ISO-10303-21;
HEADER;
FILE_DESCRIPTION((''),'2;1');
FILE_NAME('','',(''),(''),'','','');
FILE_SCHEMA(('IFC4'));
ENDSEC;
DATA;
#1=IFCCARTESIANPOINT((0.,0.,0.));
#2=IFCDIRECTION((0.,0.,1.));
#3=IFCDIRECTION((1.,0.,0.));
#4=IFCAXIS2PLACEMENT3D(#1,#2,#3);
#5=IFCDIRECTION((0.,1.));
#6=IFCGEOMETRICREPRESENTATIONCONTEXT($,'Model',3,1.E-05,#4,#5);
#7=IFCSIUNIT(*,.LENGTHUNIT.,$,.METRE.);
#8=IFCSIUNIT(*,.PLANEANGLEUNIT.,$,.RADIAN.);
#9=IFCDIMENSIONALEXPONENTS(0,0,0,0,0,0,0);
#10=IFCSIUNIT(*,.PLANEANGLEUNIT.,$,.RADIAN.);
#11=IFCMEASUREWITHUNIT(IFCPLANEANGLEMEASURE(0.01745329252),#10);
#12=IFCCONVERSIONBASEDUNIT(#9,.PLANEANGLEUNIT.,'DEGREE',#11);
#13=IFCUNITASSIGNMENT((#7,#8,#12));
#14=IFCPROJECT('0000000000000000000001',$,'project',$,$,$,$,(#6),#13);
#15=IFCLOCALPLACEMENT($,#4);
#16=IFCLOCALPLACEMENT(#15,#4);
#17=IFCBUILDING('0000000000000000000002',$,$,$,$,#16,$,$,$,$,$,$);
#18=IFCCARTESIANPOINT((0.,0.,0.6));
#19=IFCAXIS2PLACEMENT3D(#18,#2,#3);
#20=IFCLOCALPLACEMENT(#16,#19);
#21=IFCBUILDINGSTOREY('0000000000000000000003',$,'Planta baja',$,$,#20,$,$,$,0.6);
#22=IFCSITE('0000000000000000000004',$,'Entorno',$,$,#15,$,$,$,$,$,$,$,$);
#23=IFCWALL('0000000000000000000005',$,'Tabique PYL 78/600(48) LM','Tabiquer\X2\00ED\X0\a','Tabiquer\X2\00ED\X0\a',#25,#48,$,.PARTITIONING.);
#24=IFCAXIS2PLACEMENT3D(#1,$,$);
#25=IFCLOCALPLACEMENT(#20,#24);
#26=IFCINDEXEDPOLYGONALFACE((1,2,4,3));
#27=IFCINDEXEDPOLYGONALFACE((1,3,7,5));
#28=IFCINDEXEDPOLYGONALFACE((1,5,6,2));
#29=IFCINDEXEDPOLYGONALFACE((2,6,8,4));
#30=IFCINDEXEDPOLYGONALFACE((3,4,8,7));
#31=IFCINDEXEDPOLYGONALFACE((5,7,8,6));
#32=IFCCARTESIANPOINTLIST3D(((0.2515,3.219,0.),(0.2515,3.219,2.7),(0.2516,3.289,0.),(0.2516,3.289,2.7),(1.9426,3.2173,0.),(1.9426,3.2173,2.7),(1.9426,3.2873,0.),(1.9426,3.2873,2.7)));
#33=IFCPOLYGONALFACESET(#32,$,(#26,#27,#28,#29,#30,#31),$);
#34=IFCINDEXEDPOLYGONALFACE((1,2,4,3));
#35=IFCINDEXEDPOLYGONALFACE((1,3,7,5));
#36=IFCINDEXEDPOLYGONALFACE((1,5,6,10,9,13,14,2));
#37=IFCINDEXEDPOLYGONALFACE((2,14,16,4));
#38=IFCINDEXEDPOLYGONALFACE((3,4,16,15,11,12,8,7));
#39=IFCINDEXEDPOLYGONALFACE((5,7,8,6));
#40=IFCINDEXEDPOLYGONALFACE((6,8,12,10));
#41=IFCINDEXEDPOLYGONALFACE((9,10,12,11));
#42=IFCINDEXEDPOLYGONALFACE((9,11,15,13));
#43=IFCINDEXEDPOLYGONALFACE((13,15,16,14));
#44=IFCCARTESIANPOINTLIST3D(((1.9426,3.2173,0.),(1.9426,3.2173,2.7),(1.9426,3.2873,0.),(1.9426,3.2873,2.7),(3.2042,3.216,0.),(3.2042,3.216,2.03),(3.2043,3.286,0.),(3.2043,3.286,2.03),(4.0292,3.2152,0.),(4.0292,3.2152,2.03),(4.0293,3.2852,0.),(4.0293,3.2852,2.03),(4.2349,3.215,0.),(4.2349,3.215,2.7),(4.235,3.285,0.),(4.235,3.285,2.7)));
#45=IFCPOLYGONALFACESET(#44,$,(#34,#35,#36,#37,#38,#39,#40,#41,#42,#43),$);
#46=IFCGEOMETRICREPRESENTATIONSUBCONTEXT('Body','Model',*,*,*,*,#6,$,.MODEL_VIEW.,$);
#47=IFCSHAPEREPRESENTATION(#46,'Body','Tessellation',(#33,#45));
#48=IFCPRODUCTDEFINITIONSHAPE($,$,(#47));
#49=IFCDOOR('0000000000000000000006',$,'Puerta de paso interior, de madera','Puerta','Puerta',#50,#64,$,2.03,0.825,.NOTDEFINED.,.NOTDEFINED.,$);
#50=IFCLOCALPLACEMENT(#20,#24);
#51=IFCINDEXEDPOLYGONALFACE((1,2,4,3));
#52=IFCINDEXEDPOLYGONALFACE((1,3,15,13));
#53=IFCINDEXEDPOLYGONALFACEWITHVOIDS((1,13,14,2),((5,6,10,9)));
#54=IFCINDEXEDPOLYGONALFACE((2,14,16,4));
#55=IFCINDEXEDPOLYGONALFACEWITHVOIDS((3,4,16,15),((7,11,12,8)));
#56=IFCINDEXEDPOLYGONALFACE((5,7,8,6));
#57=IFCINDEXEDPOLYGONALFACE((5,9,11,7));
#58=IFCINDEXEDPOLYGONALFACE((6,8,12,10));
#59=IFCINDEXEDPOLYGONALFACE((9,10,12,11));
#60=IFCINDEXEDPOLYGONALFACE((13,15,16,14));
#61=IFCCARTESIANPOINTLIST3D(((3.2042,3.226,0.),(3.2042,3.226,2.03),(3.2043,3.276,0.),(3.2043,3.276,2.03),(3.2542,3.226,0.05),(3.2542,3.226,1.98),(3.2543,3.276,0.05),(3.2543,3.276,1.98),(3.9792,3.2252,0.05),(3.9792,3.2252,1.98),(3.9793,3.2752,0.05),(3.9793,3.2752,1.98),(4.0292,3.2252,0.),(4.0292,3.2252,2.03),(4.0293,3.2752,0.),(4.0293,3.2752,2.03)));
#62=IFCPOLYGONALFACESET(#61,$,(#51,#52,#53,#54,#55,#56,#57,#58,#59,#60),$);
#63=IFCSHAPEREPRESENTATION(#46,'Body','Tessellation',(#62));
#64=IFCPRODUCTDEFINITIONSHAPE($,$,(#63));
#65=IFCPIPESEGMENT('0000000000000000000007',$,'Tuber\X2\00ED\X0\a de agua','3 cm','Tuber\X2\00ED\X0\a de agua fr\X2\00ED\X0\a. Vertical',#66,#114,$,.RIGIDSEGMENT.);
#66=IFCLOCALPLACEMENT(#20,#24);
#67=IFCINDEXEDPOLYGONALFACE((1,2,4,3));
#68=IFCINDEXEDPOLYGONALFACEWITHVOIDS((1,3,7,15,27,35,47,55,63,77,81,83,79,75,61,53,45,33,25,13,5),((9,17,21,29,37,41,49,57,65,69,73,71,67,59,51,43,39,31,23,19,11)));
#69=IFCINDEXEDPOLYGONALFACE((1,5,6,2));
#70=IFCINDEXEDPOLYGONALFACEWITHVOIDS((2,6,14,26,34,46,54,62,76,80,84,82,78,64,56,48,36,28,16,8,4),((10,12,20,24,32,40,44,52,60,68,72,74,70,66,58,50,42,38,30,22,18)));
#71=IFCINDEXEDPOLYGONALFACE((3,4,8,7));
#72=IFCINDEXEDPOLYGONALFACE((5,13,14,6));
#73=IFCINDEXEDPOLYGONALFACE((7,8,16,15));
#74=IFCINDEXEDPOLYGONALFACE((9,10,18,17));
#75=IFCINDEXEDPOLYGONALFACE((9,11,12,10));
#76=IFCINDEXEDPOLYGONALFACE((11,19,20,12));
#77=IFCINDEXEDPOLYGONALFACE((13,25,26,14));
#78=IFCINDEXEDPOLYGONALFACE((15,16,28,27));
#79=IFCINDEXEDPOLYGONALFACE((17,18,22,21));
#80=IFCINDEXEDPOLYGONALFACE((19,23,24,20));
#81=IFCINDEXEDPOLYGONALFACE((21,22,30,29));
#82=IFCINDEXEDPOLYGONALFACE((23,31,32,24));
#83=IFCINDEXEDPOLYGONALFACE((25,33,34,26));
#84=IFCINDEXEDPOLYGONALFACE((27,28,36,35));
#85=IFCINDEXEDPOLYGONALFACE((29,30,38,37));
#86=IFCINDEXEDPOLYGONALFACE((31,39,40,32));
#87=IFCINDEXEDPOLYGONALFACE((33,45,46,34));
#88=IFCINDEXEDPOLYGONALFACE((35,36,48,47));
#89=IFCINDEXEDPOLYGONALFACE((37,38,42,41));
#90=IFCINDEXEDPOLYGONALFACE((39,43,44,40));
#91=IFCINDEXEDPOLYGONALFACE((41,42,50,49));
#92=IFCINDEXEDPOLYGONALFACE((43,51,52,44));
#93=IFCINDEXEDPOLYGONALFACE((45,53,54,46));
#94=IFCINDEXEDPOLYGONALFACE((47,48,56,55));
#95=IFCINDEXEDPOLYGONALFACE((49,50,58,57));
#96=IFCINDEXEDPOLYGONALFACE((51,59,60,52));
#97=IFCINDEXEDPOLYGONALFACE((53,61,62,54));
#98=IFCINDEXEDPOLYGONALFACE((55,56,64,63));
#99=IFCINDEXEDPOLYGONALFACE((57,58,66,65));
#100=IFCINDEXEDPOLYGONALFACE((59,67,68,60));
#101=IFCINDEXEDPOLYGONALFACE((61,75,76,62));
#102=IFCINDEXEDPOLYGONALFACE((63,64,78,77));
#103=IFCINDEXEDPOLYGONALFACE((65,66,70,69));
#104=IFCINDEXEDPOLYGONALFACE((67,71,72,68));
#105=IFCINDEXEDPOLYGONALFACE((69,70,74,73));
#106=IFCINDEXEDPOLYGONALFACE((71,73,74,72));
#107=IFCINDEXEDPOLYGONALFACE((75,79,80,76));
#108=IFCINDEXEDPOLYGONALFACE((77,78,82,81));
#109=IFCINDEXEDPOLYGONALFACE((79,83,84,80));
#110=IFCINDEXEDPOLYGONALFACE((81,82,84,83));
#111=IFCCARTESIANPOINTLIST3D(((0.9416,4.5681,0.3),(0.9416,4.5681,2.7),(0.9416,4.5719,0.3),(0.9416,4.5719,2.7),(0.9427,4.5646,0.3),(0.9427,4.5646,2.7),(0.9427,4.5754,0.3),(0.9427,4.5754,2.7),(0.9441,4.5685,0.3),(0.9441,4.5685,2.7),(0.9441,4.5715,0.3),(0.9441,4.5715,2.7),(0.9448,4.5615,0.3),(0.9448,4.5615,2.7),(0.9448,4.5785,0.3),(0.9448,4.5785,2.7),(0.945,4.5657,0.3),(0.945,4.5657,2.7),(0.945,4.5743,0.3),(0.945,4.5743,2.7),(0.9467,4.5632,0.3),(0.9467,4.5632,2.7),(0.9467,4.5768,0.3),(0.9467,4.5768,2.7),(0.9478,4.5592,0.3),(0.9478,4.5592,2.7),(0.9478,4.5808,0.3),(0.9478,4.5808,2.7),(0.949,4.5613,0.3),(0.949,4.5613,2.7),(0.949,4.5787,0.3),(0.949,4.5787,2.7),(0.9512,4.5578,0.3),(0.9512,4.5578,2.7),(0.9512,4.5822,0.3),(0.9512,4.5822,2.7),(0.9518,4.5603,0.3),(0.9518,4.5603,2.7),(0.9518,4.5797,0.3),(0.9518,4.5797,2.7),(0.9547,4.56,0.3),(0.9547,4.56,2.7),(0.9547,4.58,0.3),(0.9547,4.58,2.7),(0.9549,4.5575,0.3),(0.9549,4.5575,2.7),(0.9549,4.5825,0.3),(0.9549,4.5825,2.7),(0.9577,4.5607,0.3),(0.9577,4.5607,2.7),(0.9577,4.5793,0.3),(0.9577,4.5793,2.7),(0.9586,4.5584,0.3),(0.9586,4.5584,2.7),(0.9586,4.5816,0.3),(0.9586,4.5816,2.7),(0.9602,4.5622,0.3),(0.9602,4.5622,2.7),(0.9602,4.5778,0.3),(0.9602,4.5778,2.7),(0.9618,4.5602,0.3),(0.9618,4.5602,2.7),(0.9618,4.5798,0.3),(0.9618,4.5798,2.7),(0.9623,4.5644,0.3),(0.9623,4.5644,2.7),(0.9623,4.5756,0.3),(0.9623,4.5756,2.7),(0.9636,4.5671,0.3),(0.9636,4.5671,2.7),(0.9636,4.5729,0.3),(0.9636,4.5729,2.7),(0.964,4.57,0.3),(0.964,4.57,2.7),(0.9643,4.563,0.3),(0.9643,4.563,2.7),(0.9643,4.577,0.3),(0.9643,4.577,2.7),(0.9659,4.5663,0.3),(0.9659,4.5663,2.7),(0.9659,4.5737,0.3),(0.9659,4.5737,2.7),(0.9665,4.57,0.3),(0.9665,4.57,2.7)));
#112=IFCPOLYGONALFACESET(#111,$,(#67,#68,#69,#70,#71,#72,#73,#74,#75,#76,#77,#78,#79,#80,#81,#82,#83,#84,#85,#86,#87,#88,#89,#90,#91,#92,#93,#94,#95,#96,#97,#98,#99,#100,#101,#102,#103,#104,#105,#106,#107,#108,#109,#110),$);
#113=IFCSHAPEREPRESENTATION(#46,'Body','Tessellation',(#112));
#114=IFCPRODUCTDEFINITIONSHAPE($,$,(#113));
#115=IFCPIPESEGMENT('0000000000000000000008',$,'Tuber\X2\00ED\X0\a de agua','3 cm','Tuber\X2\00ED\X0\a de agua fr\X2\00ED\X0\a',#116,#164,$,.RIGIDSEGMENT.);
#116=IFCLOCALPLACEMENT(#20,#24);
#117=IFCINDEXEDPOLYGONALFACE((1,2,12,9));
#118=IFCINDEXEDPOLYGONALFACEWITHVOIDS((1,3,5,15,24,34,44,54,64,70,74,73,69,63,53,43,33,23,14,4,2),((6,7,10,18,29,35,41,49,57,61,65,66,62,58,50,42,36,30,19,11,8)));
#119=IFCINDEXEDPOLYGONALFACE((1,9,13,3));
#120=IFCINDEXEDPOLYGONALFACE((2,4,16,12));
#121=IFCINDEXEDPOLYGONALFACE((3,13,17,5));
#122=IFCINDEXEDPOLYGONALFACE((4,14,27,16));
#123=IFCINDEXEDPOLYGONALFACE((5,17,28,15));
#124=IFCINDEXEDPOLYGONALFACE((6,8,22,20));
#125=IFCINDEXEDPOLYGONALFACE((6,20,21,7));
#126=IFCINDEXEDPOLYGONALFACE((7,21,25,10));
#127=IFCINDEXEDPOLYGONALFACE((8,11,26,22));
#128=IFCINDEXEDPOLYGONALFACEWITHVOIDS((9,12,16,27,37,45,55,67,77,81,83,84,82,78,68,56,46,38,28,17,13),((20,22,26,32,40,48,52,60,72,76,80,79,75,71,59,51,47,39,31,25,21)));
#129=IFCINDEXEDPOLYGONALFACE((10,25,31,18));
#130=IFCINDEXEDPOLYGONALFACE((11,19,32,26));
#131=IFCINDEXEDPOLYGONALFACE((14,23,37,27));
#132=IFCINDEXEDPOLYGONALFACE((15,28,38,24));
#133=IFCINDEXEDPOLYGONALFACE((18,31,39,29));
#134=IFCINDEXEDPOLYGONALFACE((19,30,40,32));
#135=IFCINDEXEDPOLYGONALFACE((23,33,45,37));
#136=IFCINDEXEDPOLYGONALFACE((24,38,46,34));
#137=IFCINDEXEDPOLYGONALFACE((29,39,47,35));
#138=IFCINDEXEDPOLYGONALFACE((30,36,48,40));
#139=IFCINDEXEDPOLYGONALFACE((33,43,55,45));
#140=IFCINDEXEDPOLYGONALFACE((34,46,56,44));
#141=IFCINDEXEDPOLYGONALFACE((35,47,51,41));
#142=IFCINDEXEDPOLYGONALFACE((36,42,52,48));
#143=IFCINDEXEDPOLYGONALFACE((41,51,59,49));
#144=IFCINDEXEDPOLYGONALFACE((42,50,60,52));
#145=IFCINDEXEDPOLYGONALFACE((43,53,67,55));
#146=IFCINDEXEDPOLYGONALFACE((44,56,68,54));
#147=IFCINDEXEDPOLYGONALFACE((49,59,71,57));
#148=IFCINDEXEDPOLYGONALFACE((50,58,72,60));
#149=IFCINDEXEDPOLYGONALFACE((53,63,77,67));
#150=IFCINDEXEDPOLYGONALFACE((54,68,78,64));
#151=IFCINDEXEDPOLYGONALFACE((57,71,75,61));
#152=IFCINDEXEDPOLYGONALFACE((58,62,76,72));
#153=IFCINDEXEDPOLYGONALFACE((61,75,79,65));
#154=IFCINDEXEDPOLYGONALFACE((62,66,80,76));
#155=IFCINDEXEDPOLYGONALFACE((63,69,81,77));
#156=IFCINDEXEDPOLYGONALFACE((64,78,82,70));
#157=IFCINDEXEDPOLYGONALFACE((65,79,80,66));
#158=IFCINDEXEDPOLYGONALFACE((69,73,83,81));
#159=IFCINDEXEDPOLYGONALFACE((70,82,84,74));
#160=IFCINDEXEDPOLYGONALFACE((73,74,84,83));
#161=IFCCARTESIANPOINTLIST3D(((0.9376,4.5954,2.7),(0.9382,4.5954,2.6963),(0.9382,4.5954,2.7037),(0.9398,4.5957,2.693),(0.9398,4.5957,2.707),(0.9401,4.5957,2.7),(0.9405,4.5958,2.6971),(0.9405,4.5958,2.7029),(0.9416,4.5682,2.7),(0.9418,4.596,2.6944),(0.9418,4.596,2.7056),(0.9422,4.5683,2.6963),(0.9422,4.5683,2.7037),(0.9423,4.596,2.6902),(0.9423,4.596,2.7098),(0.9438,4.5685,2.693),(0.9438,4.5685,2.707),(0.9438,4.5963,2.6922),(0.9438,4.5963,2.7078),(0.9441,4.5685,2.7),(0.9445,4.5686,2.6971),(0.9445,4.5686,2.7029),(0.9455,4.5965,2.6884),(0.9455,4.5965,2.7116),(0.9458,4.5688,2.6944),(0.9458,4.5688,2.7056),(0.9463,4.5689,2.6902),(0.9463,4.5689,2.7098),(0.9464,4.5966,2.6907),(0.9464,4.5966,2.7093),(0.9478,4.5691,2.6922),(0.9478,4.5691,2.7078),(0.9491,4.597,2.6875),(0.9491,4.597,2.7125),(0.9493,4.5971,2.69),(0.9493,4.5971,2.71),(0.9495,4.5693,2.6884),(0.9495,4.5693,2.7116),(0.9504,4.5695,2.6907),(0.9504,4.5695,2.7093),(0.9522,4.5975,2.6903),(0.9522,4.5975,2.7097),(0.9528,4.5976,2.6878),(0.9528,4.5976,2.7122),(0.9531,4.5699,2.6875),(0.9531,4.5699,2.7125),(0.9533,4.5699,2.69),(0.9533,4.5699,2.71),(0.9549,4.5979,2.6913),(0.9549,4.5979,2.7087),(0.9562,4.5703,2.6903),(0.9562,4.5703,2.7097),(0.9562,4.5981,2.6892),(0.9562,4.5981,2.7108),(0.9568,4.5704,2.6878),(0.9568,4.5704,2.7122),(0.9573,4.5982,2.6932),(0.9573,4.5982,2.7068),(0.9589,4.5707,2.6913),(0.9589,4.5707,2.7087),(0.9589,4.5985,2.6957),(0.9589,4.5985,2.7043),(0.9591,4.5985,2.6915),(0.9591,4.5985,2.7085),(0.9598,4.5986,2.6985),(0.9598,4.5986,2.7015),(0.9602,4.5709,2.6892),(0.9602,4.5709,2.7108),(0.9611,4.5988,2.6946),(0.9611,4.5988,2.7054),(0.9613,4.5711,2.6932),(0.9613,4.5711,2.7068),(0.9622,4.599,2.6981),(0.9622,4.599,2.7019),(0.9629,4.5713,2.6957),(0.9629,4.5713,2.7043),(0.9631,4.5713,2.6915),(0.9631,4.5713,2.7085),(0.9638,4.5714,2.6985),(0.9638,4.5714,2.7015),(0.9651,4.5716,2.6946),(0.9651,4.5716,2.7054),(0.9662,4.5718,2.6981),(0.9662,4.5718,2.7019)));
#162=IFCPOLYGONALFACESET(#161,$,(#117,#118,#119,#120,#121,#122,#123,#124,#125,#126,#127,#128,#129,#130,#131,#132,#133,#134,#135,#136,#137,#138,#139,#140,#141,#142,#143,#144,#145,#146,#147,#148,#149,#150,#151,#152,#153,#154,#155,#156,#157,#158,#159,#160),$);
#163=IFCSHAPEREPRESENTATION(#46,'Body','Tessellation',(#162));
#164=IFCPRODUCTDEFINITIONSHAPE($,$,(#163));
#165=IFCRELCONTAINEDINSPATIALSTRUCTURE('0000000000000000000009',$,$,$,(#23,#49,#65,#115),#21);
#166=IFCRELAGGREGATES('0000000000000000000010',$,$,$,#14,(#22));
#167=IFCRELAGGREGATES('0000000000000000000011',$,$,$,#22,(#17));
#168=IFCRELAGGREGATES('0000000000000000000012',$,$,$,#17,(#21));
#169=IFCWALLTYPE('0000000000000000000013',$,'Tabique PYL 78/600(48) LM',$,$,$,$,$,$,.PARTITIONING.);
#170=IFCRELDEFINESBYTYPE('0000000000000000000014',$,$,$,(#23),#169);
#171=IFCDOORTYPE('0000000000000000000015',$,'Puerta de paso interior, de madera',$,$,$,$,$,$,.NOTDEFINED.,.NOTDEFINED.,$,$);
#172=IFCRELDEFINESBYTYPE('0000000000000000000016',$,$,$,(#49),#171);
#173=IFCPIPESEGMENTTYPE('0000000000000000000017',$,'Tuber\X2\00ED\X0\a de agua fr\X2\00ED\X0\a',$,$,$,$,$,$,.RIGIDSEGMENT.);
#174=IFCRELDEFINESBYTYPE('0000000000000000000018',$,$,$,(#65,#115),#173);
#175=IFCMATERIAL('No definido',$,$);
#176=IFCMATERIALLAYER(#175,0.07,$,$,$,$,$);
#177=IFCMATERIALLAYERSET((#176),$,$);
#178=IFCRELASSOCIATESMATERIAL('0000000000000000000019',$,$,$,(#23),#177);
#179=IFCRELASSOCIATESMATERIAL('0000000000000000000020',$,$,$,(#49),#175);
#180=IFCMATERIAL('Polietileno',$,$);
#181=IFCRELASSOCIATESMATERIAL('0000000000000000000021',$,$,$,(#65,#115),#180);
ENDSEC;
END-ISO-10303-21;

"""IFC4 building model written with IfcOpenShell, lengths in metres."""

from ifc_helpers import new_model, entity, si_unit, converted_unit, direction, frame, origin_with_axes, origin_2d_with_axis, place, context, subcontext, project, spatial, rectangle, hollow_rectangle, hollow_circle, extrude, shape, material, layer, layer_set, layer_usage, type_object, element, fill, save


model = new_model("IFC4")

# Units and contexts
model_context = context("Model", 3, precision=1e-05, world=origin_with_axes(), true_north=direction((0.0, 1.0)))
body_context = subcontext(model_context, "Body", "Model", "MODEL_VIEW")
footprint_context = subcontext(model_context, "FootPrint", "Model", "MODEL_VIEW")
ifc_project = project(units=[si_unit("LENGTHUNIT", "METRE"), si_unit("PLANEANGLEUNIT", "RADIAN"), converted_unit("PLANEANGLEUNIT", "DEGREE", entity("IfcPlaneAngleMeasure", 0.01745329252), si_unit("PLANEANGLEUNIT", "RADIAN"), dimensions=[0, 0, 0, 0, 0, 0, 0])], contexts=[model_context])

# Site, building, storey
site_placement = place(None, origin_with_axes())
site = spatial("IfcSite", under=ifc_project, at=site_placement, Name="Entorno")
building_placement = place(site_placement, origin_with_axes())
building = spatial("IfcBuilding", under=site, at=building_placement)
storey_placement = place(building_placement, frame((0.0, 0.0, 0.6), z_axis=(0.0, 0.0, 1.0), x_axis=(1.0, 0.0, 0.0)))
storey = spatial("IfcBuildingStorey", under=building, at=storey_placement, Name="Planta baja", Elevation=0.6)

# Wall, opening, door
ifc_material_1 = material(Name="No definido")
ifc_layer = layer(ifc_material_1, 0.07)
ifc_layer_set = layer_set([ifc_layer])
ifc_layer_usage = layer_usage(ifc_layer_set, "AXIS2", "POSITIVE", -0.035)
wall_type = type_object("IfcWallType", Name="Tabique PYL 78/600(48) LM", PredefinedType="PARTITIONING")
wall_placement = place(storey_placement, frame((0.1, 3.2542, 0.0), z_axis=(0.0, 0.0, 1.0), x_axis=(0.999999, -0.001016, 0.0)))
cartesian_point_1 = entity("IfcCartesianPoint", [-0.8455, -1.35])
cartesian_point_2 = entity("IfcCartesianPoint", [-0.8455, -1.35])
cartesian_point_3 = entity("IfcCartesianPoint", [-1.1462, -1.35])
cartesian_point_4 = entity("IfcCartesianPoint", [-1.1462, -1.35])
wall = element("IfcWall", 1, at=wall_placement, inside=storey, type_object=wall_type, material=ifc_layer_usage, Name="Tabique PYL 78/600(48) LM", Description="Tabiquería", ObjectType="Tabiquería", PredefinedType="PARTITIONING", context=body_context, shape_type="SolidModel", body=[
    entity("IfcExtrudedAreaSolidTapered", entity("IfcArbitraryClosedProfileDef", "AREA", None, entity("IfcPolyline", [cartesian_point_1, entity("IfcCartesianPoint", [0.8455, -1.35]), entity("IfcCartesianPoint", [0.8455, 1.35]), entity("IfcCartesianPoint", [-0.8455, 1.35]), cartesian_point_1])), entity("IfcAxis2Placement3D", entity("IfcCartesianPoint", [0.9971, 0.035, 1.35]), entity("IfcDirection", [0.0, -1.0, 0.0]), entity("IfcDirection", [1.0, 0.0, 0.0])), entity("IfcDirection", [0.0, 0.0, 1.0]), 0.07, entity("IfcArbitraryClosedProfileDef", "AREA", None, entity("IfcPolyline", [cartesian_point_2, entity("IfcCartesianPoint", [0.8455, -1.35]), entity("IfcCartesianPoint", [0.8455, 1.35]), entity("IfcCartesianPoint", [-0.8455, 1.35]), cartesian_point_2]))),
    entity("IfcExtrudedAreaSolidTapered", entity("IfcArbitraryClosedProfileDef", "AREA", None, entity("IfcPolyline", [cartesian_point_3, entity("IfcCartesianPoint", [1.1462, -1.35]), entity("IfcCartesianPoint", [1.1462, 1.35]), entity("IfcCartesianPoint", [-1.1462, 1.35]), cartesian_point_3])), entity("IfcAxis2Placement3D", entity("IfcCartesianPoint", [2.9888, 0.035, 1.35]), entity("IfcDirection", [0.0, -1.0, 0.0]), entity("IfcDirection", [1.0, 0.0, 0.0])), entity("IfcDirection", [0.0, 0.0, 1.0]), 0.07, entity("IfcArbitraryClosedProfileDef", "AREA", None, entity("IfcPolyline", [cartesian_point_4, entity("IfcCartesianPoint", [1.1462, -1.35]), entity("IfcCartesianPoint", [1.1462, 1.35]), entity("IfcCartesianPoint", [-1.1462, 1.35]), cartesian_point_4]))),
])
opening_placement = place(wall_placement, frame((3.5168, 0.0, 1.015), z_axis=(0.0, 0.0, 1.0), x_axis=(1.0, 0.0, 0.0)))
cartesian_point_5 = entity("IfcCartesianPoint", [-0.4125, -0.035])
opening = element("IfcOpeningElement", 2, at=opening_placement, cuts=wall, ObjectType="No definido", PredefinedType="OPENING", shapes=[
    shape(body_context, "Body", "SweptSolid", [extrude(rectangle(XDim=2.03, YDim=0.825, at=origin_2d_with_axis()), frame((0.0, -0.035, 0.0), z_axis=(0.0, 1.0, 0.0), x_axis=(0.0, 0.0, 1.0)), (0.0, 0.0, 1.0), 0.07)]),
    shape(footprint_context, "FootPrint", "GeometricCurveSet", [entity("IfcGeometricCurveSet", [entity("IfcPolyline", [cartesian_point_5, entity("IfcCartesianPoint", [0.4125, -0.035]), entity("IfcCartesianPoint", [0.4125, 0.035]), entity("IfcCartesianPoint", [-0.4125, 0.035]), cartesian_point_5])])]),
])
door_type = type_object("IfcDoorType", Name="Puerta de paso interior, de madera", OperationType="NOTDEFINED", PredefinedType="NOTDEFINED")
door_placement = place(opening_placement, origin_with_axes())
door = element("IfcDoor", 3, at=door_placement, inside=storey, type_object=door_type, material=ifc_material_1, Name="Puerta de paso interior, de madera", Description="Puerta", ObjectType="Puerta", OperationType="NOTDEFINED", OverallHeight=2.03, OverallWidth=0.825, PredefinedType="NOTDEFINED", context=body_context, shape_type="SweptSolid", body=[
    extrude(hollow_rectangle(XDim=0.825, YDim=2.03, WallThickness=0.05, InnerFilletRadius=0.0, OuterFilletRadius=0.0, at=origin_2d_with_axis()), frame((0.0, 0.025, 0.0), z_axis=(0.0, -1.0, 0.0), x_axis=(1.0, 0.0, 0.0)), (0.0, 0.0, 1.0), 0.05),
])
fill(opening, door)

# Pipe segments
ifc_material_2 = material(Name="Polietileno")
pipe_segment_type_1 = type_object("IfcPipeSegmentType", Name="Tubería de agua fría", PredefinedType="RIGIDSEGMENT")
pipe_segment_1_placement = place(storey_placement, frame((0.954, 4.57, 2.7), z_axis=(0.0, 0.0, -1.0), x_axis=(1.0, 0.0, 0.0)))
element("IfcPipeSegment", 4, at=pipe_segment_1_placement, inside=storey, type_object=pipe_segment_type_1, material=ifc_material_2, Name="Tubería de agua", Description="3 cm", ObjectType="Tubería de agua fría. Vertical", PredefinedType="RIGIDSEGMENT", context=body_context, shape_type="SweptSolid", body=[
    extrude(hollow_circle(Radius=0.0125, WallThickness=0.0025, at=origin_2d_with_axis()), origin_with_axes(), (0.0, 0.0, 1.0), 2.4),
])
pipe_segment_2_placement = place(storey_placement, frame((0.954, 4.57, 2.7), z_axis=(-0.145612, 0.989342, 0.0), x_axis=(-0.989342, -0.145612, 0.0)))
element("IfcPipeSegment", 5, at=pipe_segment_2_placement, inside=storey, type_object=pipe_segment_type_1, material=ifc_material_2, Name="Tubería de agua", Description="3 cm", ObjectType="Tubería de agua fría", PredefinedType="RIGIDSEGMENT", context=body_context, shape_type="SweptSolid", body=[
    extrude(hollow_circle(Radius=0.0125, WallThickness=0.0025, at=origin_2d_with_axis()), origin_with_axes(), (0.0, 0.0, 1.0), 0.0275),
])

save(model, "model.ifc")
